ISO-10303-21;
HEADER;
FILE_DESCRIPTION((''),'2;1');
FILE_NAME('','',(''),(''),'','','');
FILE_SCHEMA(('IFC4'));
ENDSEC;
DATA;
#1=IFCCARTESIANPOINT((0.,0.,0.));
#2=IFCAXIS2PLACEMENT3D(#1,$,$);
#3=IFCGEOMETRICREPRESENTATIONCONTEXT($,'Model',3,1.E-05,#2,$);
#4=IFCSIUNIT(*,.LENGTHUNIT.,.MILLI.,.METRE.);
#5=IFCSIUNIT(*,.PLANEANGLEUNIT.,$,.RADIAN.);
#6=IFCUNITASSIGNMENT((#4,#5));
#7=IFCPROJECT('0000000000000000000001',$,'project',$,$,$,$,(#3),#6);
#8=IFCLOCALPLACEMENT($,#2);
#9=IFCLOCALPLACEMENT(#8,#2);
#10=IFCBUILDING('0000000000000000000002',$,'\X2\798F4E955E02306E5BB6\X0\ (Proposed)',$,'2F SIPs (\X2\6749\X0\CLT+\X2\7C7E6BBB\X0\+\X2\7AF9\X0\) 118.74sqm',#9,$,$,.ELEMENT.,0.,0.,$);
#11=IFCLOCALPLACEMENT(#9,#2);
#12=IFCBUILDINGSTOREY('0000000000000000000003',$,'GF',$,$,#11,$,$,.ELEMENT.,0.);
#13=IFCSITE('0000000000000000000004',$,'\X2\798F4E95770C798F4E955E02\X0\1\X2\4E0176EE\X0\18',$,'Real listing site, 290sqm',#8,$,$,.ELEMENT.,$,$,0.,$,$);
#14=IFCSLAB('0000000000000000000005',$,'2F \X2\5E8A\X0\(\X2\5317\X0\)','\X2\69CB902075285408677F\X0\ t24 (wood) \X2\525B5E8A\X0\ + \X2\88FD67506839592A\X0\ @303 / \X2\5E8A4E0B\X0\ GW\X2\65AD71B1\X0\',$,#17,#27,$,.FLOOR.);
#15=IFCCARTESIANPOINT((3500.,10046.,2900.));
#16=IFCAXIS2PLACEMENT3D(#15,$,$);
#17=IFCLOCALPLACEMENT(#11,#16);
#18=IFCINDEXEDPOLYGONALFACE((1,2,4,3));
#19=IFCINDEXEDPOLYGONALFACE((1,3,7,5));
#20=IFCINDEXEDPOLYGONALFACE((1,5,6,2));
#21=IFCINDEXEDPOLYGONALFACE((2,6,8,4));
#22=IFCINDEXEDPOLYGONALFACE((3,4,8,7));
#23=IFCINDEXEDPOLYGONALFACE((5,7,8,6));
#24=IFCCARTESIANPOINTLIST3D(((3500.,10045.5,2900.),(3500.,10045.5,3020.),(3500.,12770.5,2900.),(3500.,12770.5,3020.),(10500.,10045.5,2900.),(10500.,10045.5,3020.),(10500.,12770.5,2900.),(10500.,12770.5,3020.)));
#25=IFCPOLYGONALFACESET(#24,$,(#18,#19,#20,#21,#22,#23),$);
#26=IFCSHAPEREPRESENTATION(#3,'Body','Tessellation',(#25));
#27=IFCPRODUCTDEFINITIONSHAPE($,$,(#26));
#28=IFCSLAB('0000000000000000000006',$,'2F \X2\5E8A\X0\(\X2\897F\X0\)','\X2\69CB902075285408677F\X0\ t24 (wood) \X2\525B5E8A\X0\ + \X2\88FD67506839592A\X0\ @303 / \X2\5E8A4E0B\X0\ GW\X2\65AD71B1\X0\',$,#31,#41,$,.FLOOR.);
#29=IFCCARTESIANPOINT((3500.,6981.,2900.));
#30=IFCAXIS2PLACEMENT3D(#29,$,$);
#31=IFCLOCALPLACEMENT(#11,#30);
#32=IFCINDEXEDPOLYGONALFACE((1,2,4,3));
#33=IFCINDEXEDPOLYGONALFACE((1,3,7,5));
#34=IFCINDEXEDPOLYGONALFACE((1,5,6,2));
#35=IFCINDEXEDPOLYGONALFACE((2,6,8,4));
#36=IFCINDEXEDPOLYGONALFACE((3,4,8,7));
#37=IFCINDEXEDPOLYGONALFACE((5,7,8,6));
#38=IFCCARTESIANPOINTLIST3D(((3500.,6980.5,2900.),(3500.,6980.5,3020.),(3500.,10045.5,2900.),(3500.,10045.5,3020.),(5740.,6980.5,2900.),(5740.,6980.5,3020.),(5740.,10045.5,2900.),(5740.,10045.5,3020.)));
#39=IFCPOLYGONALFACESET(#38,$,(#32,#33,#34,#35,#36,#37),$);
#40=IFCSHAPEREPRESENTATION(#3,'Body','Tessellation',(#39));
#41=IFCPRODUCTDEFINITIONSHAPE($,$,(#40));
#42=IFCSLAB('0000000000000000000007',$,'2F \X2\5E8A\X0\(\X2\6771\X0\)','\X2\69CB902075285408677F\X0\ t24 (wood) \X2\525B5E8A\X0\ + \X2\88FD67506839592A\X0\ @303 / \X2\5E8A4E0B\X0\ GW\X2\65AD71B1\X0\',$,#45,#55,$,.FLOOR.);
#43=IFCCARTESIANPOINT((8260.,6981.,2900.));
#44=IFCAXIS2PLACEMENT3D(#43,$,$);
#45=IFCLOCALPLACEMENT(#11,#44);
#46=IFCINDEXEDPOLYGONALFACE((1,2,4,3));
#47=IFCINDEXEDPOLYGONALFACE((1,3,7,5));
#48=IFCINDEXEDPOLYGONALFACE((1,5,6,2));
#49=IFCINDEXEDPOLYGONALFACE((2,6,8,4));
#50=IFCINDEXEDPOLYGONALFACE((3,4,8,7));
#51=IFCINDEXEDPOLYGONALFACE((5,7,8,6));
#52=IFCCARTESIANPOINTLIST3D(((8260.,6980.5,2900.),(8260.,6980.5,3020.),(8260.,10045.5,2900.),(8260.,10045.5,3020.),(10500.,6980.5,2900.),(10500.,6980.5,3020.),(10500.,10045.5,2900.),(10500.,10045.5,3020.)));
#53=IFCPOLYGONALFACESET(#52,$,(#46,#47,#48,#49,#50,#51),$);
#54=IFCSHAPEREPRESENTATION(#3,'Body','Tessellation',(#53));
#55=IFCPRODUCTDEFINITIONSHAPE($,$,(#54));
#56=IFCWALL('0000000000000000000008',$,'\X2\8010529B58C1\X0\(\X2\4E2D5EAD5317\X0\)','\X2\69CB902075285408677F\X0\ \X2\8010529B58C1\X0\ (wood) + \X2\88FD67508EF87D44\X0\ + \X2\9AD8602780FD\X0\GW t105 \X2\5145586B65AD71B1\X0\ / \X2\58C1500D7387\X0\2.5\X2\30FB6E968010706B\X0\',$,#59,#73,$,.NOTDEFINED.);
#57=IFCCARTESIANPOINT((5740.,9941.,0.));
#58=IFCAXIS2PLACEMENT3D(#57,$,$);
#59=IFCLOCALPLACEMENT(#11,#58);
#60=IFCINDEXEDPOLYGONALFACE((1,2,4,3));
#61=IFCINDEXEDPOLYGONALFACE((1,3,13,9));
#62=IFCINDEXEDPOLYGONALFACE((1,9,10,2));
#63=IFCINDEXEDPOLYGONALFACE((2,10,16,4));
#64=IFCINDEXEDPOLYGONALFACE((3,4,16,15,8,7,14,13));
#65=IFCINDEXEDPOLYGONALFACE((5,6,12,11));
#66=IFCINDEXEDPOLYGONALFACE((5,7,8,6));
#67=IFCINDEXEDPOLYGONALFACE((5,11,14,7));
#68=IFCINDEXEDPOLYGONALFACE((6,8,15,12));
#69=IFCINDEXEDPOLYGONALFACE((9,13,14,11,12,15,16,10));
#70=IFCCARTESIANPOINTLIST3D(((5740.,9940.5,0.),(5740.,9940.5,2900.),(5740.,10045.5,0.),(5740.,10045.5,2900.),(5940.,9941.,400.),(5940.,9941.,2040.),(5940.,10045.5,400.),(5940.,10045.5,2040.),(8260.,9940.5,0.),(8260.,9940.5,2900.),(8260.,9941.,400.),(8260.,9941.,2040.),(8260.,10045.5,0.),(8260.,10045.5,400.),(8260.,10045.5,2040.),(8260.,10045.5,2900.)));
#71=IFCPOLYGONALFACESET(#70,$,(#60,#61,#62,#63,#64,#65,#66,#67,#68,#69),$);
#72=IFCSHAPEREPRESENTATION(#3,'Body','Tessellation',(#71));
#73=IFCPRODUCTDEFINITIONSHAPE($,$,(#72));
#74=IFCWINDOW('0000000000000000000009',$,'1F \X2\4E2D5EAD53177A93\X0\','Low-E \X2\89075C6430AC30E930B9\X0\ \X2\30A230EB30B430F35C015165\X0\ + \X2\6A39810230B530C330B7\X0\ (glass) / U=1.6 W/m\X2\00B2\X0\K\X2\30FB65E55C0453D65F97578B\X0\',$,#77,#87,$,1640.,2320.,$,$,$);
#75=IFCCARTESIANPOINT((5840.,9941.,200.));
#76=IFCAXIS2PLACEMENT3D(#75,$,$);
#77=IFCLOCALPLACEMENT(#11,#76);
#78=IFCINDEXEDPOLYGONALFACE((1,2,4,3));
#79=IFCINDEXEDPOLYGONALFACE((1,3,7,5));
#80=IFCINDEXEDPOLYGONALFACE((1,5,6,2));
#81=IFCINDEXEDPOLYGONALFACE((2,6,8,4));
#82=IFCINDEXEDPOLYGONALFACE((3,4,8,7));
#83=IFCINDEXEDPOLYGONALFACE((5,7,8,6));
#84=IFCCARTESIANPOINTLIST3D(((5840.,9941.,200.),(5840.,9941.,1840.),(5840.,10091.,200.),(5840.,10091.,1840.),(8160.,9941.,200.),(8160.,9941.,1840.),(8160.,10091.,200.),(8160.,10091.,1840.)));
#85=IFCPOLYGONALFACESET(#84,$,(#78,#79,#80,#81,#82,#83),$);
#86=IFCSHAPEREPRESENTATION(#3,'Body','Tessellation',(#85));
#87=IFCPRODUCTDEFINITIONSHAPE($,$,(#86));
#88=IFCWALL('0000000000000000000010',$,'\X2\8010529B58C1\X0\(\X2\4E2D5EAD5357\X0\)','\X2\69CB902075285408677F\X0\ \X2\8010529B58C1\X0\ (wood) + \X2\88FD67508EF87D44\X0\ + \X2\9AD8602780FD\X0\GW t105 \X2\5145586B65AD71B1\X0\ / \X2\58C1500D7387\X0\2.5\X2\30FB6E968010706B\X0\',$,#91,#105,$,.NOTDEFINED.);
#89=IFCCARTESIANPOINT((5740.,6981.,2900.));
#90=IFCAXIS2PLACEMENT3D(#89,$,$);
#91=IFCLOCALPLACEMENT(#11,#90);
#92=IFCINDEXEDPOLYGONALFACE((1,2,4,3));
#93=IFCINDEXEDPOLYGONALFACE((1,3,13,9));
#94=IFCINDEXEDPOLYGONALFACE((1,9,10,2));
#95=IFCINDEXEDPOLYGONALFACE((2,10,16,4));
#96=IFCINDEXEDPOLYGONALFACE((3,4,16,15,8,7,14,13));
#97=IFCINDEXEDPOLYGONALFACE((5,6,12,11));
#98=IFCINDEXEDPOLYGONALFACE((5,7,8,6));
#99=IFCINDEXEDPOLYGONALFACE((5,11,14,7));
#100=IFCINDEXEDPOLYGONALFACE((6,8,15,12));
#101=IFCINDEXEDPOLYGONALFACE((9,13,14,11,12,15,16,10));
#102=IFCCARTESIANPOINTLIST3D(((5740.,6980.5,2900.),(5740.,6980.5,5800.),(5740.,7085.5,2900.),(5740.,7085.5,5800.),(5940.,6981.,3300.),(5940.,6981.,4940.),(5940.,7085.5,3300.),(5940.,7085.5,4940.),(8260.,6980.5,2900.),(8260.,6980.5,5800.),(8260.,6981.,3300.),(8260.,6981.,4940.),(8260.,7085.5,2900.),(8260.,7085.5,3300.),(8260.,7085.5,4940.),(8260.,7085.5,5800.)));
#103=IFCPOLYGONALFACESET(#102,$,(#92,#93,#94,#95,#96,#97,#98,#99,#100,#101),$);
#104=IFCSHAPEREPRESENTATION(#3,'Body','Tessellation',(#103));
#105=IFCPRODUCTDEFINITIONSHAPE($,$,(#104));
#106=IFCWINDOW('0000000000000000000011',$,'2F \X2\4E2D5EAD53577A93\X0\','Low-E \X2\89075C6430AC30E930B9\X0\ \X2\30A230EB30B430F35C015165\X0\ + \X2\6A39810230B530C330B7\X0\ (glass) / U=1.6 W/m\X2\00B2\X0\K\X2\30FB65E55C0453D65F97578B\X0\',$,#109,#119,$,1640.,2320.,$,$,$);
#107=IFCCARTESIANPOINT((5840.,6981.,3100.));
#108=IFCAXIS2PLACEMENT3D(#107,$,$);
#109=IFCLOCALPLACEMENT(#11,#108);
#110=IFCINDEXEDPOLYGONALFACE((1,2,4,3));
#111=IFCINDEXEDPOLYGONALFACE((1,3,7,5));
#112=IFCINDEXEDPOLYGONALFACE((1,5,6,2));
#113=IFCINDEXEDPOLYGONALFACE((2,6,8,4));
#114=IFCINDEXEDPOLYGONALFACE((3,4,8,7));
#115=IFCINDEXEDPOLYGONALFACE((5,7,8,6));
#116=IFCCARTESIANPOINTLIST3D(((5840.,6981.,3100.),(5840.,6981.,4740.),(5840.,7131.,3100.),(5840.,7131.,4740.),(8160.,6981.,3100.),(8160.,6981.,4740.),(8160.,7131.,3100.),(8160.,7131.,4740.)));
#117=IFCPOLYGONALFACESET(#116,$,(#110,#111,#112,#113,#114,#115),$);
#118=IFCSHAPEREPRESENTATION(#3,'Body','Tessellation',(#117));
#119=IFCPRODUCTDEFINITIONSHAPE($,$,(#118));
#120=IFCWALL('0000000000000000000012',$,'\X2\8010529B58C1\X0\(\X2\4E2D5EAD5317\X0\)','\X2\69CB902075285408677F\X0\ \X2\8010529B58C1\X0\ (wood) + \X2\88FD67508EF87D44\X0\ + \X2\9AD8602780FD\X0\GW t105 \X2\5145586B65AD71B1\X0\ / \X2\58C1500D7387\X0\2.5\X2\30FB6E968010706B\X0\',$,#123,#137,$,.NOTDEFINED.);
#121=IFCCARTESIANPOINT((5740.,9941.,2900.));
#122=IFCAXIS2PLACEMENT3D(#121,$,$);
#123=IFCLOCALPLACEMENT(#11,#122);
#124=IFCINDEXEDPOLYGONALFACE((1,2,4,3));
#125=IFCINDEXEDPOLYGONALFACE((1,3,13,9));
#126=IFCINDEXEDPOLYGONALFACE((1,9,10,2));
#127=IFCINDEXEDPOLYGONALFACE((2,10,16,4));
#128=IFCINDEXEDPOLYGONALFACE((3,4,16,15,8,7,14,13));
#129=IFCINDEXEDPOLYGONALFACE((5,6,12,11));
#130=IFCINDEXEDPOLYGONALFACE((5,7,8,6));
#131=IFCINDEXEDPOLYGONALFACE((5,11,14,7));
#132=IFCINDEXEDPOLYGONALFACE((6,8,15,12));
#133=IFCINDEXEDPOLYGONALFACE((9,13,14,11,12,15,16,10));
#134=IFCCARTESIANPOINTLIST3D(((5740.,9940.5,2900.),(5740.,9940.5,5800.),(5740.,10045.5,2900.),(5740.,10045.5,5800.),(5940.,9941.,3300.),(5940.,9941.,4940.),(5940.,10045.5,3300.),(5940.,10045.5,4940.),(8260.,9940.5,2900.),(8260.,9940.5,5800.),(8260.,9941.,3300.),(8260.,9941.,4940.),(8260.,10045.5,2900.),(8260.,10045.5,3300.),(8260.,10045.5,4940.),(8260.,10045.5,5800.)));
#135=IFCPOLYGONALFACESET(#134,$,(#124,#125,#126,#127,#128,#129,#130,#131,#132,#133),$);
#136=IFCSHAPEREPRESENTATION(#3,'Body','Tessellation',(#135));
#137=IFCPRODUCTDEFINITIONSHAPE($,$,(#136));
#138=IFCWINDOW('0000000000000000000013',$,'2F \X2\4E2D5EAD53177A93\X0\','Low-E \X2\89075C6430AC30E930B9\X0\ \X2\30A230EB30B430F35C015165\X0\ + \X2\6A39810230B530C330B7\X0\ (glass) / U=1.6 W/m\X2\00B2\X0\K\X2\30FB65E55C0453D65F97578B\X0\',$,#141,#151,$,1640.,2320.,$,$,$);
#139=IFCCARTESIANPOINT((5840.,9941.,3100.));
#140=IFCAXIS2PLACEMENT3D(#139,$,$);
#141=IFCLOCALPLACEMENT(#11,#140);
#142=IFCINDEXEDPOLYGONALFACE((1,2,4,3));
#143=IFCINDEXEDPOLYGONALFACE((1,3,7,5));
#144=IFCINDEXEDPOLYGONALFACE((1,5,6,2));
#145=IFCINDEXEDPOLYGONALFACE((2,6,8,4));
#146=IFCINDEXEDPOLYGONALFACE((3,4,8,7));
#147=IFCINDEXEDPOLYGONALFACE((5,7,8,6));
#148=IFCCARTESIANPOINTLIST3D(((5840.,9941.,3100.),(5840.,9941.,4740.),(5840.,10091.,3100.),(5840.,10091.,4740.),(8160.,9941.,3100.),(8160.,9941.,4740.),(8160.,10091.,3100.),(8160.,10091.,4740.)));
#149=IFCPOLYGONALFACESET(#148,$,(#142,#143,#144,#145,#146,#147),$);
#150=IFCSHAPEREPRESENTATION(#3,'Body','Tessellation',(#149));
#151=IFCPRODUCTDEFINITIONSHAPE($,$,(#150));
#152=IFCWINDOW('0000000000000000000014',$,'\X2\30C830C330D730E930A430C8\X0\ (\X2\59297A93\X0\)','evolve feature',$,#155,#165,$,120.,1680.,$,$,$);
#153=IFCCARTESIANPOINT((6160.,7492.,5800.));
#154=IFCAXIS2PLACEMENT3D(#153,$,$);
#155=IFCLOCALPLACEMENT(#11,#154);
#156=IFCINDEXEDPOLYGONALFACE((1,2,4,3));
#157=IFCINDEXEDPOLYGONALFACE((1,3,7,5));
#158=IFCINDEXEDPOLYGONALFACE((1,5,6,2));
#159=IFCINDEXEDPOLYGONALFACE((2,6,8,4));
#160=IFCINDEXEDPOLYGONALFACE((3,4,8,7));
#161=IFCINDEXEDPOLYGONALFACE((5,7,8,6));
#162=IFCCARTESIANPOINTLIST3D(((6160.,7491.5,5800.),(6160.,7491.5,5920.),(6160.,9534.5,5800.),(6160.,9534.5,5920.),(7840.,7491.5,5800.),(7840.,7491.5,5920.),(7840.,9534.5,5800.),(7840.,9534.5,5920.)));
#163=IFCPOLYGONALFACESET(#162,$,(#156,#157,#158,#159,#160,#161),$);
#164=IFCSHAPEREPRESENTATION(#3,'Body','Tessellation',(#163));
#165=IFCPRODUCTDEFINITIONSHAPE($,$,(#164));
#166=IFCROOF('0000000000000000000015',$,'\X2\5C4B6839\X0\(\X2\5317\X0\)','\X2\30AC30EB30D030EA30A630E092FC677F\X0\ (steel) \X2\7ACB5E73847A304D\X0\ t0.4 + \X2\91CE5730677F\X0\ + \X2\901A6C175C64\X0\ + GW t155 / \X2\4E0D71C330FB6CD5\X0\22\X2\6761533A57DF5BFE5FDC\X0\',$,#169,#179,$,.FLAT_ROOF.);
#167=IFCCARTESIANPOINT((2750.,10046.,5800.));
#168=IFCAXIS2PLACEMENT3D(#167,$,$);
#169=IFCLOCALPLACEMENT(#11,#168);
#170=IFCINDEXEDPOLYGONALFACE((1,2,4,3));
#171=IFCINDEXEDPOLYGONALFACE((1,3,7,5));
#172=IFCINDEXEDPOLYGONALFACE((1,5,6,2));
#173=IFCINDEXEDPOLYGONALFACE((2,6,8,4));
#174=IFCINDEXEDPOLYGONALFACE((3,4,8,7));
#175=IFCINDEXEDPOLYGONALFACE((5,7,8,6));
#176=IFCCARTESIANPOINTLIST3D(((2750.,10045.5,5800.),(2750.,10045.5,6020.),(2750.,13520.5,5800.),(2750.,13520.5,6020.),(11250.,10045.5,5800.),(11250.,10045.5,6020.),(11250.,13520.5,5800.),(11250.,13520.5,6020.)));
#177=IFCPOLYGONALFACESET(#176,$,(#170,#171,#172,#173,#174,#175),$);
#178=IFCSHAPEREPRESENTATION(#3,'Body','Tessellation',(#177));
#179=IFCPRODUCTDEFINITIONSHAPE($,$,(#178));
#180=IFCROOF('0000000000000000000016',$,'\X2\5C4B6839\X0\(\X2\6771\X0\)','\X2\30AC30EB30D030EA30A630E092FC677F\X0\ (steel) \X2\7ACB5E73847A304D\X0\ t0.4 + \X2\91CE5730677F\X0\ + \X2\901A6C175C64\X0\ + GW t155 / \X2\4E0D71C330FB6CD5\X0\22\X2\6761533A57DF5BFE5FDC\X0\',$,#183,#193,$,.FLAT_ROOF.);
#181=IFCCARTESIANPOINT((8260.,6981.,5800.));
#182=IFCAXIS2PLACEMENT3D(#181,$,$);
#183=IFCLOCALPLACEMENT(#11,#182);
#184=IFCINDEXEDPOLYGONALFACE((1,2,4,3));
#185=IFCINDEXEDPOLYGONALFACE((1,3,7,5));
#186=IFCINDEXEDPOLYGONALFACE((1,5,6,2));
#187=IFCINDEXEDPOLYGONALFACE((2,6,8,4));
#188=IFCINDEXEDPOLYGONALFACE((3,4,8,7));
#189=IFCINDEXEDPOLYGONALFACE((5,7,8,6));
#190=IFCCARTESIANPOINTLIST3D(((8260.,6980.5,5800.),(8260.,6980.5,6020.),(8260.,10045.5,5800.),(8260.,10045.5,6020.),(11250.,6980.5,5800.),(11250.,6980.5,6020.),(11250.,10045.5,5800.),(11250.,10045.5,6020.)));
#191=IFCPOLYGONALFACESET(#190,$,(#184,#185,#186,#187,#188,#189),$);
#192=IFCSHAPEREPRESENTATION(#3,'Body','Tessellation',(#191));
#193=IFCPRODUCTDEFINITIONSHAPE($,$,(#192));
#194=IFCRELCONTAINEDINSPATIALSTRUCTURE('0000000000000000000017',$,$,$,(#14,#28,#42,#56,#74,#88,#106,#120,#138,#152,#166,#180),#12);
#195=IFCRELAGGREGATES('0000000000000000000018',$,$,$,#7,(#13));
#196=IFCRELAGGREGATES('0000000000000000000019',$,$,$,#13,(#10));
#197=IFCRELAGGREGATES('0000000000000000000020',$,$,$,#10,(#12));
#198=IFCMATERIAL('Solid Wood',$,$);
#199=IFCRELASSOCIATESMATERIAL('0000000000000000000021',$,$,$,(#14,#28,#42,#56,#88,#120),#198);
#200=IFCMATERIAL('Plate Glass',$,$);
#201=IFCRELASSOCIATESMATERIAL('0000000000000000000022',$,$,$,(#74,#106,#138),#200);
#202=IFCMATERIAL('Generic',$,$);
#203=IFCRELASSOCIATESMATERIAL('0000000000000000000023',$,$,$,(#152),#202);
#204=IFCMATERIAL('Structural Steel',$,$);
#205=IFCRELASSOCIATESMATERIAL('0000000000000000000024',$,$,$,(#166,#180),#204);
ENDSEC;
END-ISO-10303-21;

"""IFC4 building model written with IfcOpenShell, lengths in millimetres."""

from ifc_helpers import new_model, si_unit, frame, frame_2d, origin, place, context, project, spatial, rectangle, extrude, material, element, fill, save


model = new_model("IFC4")

# Units and contexts
model_context = context("Model", 3, precision=1e-05, world=origin())
ifc_project = project(units=[si_unit("LENGTHUNIT", "METRE", prefix="MILLI"), si_unit("PLANEANGLEUNIT", "RADIAN")], contexts=[model_context])

# Site, building, storey
site_placement = place(None, origin())
site = spatial("IfcSite", under=ifc_project, at=site_placement, Name="福井県福井市1丁目18", ObjectType="Real listing site, 290sqm", CompositionType="ELEMENT", RefElevation=0.0)
building_placement = place(site_placement, origin())
building = spatial("IfcBuilding", under=site, at=building_placement, Name="福井市の家 (Proposed)", ObjectType="2F SIPs (杉CLT+籾殻+竹) 118.74sqm", CompositionType="ELEMENT", ElevationOfRefHeight=0.0, ElevationOfTerrain=0.0)
storey_placement = place(building_placement, origin())
storey = spatial("IfcBuildingStorey", under=building, at=storey_placement, Name="GF", CompositionType="ELEMENT", Elevation=0.0)

# Slabs
ifc_material_1 = material(Name="Solid Wood")
slab_1_placement = place(storey_placement, frame((3500.0, 10046.0, 2900.0)))
element("IfcSlab", 1, at=slab_1_placement, inside=storey, material=ifc_material_1, Name="2F 床(北)", Description="構造用合板 t24 (wood) 剛床 + 製材根太 @303 / 床下 GW断熱", PredefinedType="FLOOR", context=model_context, shape_type="SweptSolid", body=[
    extrude(rectangle(XDim=7000.0, YDim=2725.0, at=frame_2d((3500.0, 1362.0))), frame((3500.0, 10046.0, 2900.0)), (0.0, 0.0, 1.0), 120.0),
])
slab_2_placement = place(storey_placement, frame((3500.0, 6981.0, 2900.0)))
element("IfcSlab", 2, at=slab_2_placement, inside=storey, material=ifc_material_1, Name="2F 床(西)", Description="構造用合板 t24 (wood) 剛床 + 製材根太 @303 / 床下 GW断熱", PredefinedType="FLOOR", context=model_context, shape_type="SweptSolid", body=[
    extrude(rectangle(XDim=2240.0, YDim=3065.0, at=frame_2d((1120.0, 1532.0))), frame((3500.0, 6981.0, 2900.0)), (0.0, 0.0, 1.0), 120.0),
])
slab_3_placement = place(storey_placement, frame((8260.0, 6981.0, 2900.0)))
element("IfcSlab", 3, at=slab_3_placement, inside=storey, material=ifc_material_1, Name="2F 床(東)", Description="構造用合板 t24 (wood) 剛床 + 製材根太 @303 / 床下 GW断熱", PredefinedType="FLOOR", context=model_context, shape_type="SweptSolid", body=[
    extrude(rectangle(XDim=2240.0, YDim=3065.0, at=frame_2d((1120.0, 1532.0))), frame((8260.0, 6981.0, 2900.0)), (0.0, 0.0, 1.0), 120.0),
])

# Wall, opening, window
wall_1_placement = place(storey_placement, frame((5740.0, 9941.0, 0.0)))
wall_1 = element("IfcWall", 4, at=wall_1_placement, inside=storey, material=ifc_material_1, Name="耐力壁(中庭北)", Description="構造用合板 耐力壁 (wood) + 製材軸組 + 高性能GW t105 充填断熱 / 壁倍率2.5・準耐火", PredefinedType="NOTDEFINED", context=model_context, shape_type="SweptSolid", body=[
    extrude(rectangle(XDim=2520.0, YDim=105.0, at=frame_2d((1260.0, 52.0))), frame((5740.0, 9941.0, 0.0)), (0.0, 0.0, 1.0), 2900.0),
])
opening_1_placement = place(storey_placement, frame((5840.0, 9941.0, 200.0)))
opening_1 = element("IfcOpeningElement", 5, at=opening_1_placement, cuts=wall_1, PredefinedType="NOTDEFINED", context=model_context, shape_type="SweptSolid", body=[
    extrude(rectangle(XDim=2320.0, YDim=150.0, at=frame_2d((1160.0, 75.0))), frame((5840.0, 9941.0, 200.0)), (0.0, 0.0, 1.0), 1640.0),
])
ifc_material_2 = material(Name="Plate Glass")
window_1_placement = place(storey_placement, frame((5840.0, 9941.0, 200.0)))
window_1 = element("IfcWindow", 6, at=window_1_placement, inside=storey, material=ifc_material_2, Name="1F 中庭北窓", Description="Low-E 複層ガラス アルゴン封入 + 樹脂サッシ (glass) / U=1.6 W/m²K・日射取得型", OverallHeight=1640.0, OverallWidth=2320.0, context=model_context, shape_type="SweptSolid", body=[
    extrude(rectangle(XDim=2320.0, YDim=150.0, at=frame_2d((1160.0, 75.0))), frame((5840.0, 9941.0, 200.0)), (0.0, 0.0, 1.0), 1640.0),
])
fill(opening_1, window_1)

# Walls, openings, windows
wall_2_placement = place(storey_placement, frame((5740.0, 6981.0, 2900.0)))
wall_2 = element("IfcWall", 7, at=wall_2_placement, inside=storey, material=ifc_material_1, Name="耐力壁(中庭南)", Description="構造用合板 耐力壁 (wood) + 製材軸組 + 高性能GW t105 充填断熱 / 壁倍率2.5・準耐火", PredefinedType="NOTDEFINED", context=model_context, shape_type="SweptSolid", body=[
    extrude(rectangle(XDim=2520.0, YDim=105.0, at=frame_2d((1260.0, 52.0))), frame((5740.0, 6981.0, 2900.0)), (0.0, 0.0, 1.0), 2900.0),
])
opening_2_placement = place(storey_placement, frame((5840.0, 6981.0, 3100.0)))
opening_2 = element("IfcOpeningElement", 8, at=opening_2_placement, cuts=wall_2, PredefinedType="NOTDEFINED", context=model_context, shape_type="SweptSolid", body=[
    extrude(rectangle(XDim=2320.0, YDim=150.0, at=frame_2d((1160.0, 75.0))), frame((5840.0, 6981.0, 3100.0)), (0.0, 0.0, 1.0), 1640.0),
])
window_2_placement = place(storey_placement, frame((5840.0, 6981.0, 3100.0)))
window_2 = element("IfcWindow", 9, at=window_2_placement, inside=storey, material=ifc_material_2, Name="2F 中庭南窓", Description="Low-E 複層ガラス アルゴン封入 + 樹脂サッシ (glass) / U=1.6 W/m²K・日射取得型", OverallHeight=1640.0, OverallWidth=2320.0, context=model_context, shape_type="SweptSolid", body=[
    extrude(rectangle(XDim=2320.0, YDim=150.0, at=frame_2d((1160.0, 75.0))), frame((5840.0, 6981.0, 3100.0)), (0.0, 0.0, 1.0), 1640.0),
])
fill(opening_2, window_2)
wall_3_placement = place(storey_placement, frame((5740.0, 9941.0, 2900.0)))
wall_3 = element("IfcWall", 10, at=wall_3_placement, inside=storey, material=ifc_material_1, Name="耐力壁(中庭北)", Description="構造用合板 耐力壁 (wood) + 製材軸組 + 高性能GW t105 充填断熱 / 壁倍率2.5・準耐火", PredefinedType="NOTDEFINED", context=model_context, shape_type="SweptSolid", body=[
    extrude(rectangle(XDim=2520.0, YDim=105.0, at=frame_2d((1260.0, 52.0))), frame((5740.0, 9941.0, 2900.0)), (0.0, 0.0, 1.0), 2900.0),
])
opening_3_placement = place(storey_placement, frame((5840.0, 9941.0, 3100.0)))
opening_3 = element("IfcOpeningElement", 11, at=opening_3_placement, cuts=wall_3, PredefinedType="NOTDEFINED", context=model_context, shape_type="SweptSolid", body=[
    extrude(rectangle(XDim=2320.0, YDim=150.0, at=frame_2d((1160.0, 75.0))), frame((5840.0, 9941.0, 3100.0)), (0.0, 0.0, 1.0), 1640.0),
])
window_3_placement = place(storey_placement, frame((5840.0, 9941.0, 3100.0)))
window_3 = element("IfcWindow", 12, at=window_3_placement, inside=storey, material=ifc_material_2, Name="2F 中庭北窓", Description="Low-E 複層ガラス アルゴン封入 + 樹脂サッシ (glass) / U=1.6 W/m²K・日射取得型", OverallHeight=1640.0, OverallWidth=2320.0, context=model_context, shape_type="SweptSolid", body=[
    extrude(rectangle(XDim=2320.0, YDim=150.0, at=frame_2d((1160.0, 75.0))), frame((5840.0, 9941.0, 3100.0)), (0.0, 0.0, 1.0), 1640.0),
])
fill(opening_3, window_3)

# Window
ifc_material_3 = material(Name="Generic")
window_4_placement = place(storey_placement, frame((6160.0, 7492.0, 5800.0)))
element("IfcWindow", 13, at=window_4_placement, inside=storey, material=ifc_material_3, Name="トップライト (天窓)", Description="evolve feature", OverallHeight=120.0, OverallWidth=1680.0, context=model_context, shape_type="SweptSolid", body=[
    extrude(rectangle(XDim=1680.0, YDim=2043.0, at=frame_2d((840.0, 1021.0))), frame((6160.0, 7492.0, 5800.0)), (0.0, 0.0, 1.0), 120.0),
])

# Roofs
ifc_material_4 = material(Name="Structural Steel")
roof_1_placement = place(storey_placement, frame((2750.0, 10046.0, 5800.0)))
element("IfcRoof", 14, at=roof_1_placement, inside=storey, material=ifc_material_4, Name="屋根(北)", Description="ガルバリウム鋼板 (steel) 立平葺き t0.4 + 野地板 + 通気層 + GW t155 / 不燃・法22条区域対応", PredefinedType="FLAT_ROOF", context=model_context, shape_type="SweptSolid", body=[
    extrude(rectangle(XDim=8500.0, YDim=3475.0, at=frame_2d((4250.0, 1737.0))), frame((2750.0, 10046.0, 5800.0)), (0.0, 0.0, 1.0), 220.0),
])
roof_2_placement = place(storey_placement, frame((8260.0, 6981.0, 5800.0)))
element("IfcRoof", 15, at=roof_2_placement, inside=storey, material=ifc_material_4, Name="屋根(東)", Description="ガルバリウム鋼板 (steel) 立平葺き t0.4 + 野地板 + 通気層 + GW t155 / 不燃・法22条区域対応", PredefinedType="FLAT_ROOF", context=model_context, shape_type="SweptSolid", body=[
    extrude(rectangle(XDim=2990.0, YDim=3065.0, at=frame_2d((1495.0, 1532.0))), frame((8260.0, 6981.0, 5800.0)), (0.0, 0.0, 1.0), 220.0),
])

save(model, "model.ifc")
